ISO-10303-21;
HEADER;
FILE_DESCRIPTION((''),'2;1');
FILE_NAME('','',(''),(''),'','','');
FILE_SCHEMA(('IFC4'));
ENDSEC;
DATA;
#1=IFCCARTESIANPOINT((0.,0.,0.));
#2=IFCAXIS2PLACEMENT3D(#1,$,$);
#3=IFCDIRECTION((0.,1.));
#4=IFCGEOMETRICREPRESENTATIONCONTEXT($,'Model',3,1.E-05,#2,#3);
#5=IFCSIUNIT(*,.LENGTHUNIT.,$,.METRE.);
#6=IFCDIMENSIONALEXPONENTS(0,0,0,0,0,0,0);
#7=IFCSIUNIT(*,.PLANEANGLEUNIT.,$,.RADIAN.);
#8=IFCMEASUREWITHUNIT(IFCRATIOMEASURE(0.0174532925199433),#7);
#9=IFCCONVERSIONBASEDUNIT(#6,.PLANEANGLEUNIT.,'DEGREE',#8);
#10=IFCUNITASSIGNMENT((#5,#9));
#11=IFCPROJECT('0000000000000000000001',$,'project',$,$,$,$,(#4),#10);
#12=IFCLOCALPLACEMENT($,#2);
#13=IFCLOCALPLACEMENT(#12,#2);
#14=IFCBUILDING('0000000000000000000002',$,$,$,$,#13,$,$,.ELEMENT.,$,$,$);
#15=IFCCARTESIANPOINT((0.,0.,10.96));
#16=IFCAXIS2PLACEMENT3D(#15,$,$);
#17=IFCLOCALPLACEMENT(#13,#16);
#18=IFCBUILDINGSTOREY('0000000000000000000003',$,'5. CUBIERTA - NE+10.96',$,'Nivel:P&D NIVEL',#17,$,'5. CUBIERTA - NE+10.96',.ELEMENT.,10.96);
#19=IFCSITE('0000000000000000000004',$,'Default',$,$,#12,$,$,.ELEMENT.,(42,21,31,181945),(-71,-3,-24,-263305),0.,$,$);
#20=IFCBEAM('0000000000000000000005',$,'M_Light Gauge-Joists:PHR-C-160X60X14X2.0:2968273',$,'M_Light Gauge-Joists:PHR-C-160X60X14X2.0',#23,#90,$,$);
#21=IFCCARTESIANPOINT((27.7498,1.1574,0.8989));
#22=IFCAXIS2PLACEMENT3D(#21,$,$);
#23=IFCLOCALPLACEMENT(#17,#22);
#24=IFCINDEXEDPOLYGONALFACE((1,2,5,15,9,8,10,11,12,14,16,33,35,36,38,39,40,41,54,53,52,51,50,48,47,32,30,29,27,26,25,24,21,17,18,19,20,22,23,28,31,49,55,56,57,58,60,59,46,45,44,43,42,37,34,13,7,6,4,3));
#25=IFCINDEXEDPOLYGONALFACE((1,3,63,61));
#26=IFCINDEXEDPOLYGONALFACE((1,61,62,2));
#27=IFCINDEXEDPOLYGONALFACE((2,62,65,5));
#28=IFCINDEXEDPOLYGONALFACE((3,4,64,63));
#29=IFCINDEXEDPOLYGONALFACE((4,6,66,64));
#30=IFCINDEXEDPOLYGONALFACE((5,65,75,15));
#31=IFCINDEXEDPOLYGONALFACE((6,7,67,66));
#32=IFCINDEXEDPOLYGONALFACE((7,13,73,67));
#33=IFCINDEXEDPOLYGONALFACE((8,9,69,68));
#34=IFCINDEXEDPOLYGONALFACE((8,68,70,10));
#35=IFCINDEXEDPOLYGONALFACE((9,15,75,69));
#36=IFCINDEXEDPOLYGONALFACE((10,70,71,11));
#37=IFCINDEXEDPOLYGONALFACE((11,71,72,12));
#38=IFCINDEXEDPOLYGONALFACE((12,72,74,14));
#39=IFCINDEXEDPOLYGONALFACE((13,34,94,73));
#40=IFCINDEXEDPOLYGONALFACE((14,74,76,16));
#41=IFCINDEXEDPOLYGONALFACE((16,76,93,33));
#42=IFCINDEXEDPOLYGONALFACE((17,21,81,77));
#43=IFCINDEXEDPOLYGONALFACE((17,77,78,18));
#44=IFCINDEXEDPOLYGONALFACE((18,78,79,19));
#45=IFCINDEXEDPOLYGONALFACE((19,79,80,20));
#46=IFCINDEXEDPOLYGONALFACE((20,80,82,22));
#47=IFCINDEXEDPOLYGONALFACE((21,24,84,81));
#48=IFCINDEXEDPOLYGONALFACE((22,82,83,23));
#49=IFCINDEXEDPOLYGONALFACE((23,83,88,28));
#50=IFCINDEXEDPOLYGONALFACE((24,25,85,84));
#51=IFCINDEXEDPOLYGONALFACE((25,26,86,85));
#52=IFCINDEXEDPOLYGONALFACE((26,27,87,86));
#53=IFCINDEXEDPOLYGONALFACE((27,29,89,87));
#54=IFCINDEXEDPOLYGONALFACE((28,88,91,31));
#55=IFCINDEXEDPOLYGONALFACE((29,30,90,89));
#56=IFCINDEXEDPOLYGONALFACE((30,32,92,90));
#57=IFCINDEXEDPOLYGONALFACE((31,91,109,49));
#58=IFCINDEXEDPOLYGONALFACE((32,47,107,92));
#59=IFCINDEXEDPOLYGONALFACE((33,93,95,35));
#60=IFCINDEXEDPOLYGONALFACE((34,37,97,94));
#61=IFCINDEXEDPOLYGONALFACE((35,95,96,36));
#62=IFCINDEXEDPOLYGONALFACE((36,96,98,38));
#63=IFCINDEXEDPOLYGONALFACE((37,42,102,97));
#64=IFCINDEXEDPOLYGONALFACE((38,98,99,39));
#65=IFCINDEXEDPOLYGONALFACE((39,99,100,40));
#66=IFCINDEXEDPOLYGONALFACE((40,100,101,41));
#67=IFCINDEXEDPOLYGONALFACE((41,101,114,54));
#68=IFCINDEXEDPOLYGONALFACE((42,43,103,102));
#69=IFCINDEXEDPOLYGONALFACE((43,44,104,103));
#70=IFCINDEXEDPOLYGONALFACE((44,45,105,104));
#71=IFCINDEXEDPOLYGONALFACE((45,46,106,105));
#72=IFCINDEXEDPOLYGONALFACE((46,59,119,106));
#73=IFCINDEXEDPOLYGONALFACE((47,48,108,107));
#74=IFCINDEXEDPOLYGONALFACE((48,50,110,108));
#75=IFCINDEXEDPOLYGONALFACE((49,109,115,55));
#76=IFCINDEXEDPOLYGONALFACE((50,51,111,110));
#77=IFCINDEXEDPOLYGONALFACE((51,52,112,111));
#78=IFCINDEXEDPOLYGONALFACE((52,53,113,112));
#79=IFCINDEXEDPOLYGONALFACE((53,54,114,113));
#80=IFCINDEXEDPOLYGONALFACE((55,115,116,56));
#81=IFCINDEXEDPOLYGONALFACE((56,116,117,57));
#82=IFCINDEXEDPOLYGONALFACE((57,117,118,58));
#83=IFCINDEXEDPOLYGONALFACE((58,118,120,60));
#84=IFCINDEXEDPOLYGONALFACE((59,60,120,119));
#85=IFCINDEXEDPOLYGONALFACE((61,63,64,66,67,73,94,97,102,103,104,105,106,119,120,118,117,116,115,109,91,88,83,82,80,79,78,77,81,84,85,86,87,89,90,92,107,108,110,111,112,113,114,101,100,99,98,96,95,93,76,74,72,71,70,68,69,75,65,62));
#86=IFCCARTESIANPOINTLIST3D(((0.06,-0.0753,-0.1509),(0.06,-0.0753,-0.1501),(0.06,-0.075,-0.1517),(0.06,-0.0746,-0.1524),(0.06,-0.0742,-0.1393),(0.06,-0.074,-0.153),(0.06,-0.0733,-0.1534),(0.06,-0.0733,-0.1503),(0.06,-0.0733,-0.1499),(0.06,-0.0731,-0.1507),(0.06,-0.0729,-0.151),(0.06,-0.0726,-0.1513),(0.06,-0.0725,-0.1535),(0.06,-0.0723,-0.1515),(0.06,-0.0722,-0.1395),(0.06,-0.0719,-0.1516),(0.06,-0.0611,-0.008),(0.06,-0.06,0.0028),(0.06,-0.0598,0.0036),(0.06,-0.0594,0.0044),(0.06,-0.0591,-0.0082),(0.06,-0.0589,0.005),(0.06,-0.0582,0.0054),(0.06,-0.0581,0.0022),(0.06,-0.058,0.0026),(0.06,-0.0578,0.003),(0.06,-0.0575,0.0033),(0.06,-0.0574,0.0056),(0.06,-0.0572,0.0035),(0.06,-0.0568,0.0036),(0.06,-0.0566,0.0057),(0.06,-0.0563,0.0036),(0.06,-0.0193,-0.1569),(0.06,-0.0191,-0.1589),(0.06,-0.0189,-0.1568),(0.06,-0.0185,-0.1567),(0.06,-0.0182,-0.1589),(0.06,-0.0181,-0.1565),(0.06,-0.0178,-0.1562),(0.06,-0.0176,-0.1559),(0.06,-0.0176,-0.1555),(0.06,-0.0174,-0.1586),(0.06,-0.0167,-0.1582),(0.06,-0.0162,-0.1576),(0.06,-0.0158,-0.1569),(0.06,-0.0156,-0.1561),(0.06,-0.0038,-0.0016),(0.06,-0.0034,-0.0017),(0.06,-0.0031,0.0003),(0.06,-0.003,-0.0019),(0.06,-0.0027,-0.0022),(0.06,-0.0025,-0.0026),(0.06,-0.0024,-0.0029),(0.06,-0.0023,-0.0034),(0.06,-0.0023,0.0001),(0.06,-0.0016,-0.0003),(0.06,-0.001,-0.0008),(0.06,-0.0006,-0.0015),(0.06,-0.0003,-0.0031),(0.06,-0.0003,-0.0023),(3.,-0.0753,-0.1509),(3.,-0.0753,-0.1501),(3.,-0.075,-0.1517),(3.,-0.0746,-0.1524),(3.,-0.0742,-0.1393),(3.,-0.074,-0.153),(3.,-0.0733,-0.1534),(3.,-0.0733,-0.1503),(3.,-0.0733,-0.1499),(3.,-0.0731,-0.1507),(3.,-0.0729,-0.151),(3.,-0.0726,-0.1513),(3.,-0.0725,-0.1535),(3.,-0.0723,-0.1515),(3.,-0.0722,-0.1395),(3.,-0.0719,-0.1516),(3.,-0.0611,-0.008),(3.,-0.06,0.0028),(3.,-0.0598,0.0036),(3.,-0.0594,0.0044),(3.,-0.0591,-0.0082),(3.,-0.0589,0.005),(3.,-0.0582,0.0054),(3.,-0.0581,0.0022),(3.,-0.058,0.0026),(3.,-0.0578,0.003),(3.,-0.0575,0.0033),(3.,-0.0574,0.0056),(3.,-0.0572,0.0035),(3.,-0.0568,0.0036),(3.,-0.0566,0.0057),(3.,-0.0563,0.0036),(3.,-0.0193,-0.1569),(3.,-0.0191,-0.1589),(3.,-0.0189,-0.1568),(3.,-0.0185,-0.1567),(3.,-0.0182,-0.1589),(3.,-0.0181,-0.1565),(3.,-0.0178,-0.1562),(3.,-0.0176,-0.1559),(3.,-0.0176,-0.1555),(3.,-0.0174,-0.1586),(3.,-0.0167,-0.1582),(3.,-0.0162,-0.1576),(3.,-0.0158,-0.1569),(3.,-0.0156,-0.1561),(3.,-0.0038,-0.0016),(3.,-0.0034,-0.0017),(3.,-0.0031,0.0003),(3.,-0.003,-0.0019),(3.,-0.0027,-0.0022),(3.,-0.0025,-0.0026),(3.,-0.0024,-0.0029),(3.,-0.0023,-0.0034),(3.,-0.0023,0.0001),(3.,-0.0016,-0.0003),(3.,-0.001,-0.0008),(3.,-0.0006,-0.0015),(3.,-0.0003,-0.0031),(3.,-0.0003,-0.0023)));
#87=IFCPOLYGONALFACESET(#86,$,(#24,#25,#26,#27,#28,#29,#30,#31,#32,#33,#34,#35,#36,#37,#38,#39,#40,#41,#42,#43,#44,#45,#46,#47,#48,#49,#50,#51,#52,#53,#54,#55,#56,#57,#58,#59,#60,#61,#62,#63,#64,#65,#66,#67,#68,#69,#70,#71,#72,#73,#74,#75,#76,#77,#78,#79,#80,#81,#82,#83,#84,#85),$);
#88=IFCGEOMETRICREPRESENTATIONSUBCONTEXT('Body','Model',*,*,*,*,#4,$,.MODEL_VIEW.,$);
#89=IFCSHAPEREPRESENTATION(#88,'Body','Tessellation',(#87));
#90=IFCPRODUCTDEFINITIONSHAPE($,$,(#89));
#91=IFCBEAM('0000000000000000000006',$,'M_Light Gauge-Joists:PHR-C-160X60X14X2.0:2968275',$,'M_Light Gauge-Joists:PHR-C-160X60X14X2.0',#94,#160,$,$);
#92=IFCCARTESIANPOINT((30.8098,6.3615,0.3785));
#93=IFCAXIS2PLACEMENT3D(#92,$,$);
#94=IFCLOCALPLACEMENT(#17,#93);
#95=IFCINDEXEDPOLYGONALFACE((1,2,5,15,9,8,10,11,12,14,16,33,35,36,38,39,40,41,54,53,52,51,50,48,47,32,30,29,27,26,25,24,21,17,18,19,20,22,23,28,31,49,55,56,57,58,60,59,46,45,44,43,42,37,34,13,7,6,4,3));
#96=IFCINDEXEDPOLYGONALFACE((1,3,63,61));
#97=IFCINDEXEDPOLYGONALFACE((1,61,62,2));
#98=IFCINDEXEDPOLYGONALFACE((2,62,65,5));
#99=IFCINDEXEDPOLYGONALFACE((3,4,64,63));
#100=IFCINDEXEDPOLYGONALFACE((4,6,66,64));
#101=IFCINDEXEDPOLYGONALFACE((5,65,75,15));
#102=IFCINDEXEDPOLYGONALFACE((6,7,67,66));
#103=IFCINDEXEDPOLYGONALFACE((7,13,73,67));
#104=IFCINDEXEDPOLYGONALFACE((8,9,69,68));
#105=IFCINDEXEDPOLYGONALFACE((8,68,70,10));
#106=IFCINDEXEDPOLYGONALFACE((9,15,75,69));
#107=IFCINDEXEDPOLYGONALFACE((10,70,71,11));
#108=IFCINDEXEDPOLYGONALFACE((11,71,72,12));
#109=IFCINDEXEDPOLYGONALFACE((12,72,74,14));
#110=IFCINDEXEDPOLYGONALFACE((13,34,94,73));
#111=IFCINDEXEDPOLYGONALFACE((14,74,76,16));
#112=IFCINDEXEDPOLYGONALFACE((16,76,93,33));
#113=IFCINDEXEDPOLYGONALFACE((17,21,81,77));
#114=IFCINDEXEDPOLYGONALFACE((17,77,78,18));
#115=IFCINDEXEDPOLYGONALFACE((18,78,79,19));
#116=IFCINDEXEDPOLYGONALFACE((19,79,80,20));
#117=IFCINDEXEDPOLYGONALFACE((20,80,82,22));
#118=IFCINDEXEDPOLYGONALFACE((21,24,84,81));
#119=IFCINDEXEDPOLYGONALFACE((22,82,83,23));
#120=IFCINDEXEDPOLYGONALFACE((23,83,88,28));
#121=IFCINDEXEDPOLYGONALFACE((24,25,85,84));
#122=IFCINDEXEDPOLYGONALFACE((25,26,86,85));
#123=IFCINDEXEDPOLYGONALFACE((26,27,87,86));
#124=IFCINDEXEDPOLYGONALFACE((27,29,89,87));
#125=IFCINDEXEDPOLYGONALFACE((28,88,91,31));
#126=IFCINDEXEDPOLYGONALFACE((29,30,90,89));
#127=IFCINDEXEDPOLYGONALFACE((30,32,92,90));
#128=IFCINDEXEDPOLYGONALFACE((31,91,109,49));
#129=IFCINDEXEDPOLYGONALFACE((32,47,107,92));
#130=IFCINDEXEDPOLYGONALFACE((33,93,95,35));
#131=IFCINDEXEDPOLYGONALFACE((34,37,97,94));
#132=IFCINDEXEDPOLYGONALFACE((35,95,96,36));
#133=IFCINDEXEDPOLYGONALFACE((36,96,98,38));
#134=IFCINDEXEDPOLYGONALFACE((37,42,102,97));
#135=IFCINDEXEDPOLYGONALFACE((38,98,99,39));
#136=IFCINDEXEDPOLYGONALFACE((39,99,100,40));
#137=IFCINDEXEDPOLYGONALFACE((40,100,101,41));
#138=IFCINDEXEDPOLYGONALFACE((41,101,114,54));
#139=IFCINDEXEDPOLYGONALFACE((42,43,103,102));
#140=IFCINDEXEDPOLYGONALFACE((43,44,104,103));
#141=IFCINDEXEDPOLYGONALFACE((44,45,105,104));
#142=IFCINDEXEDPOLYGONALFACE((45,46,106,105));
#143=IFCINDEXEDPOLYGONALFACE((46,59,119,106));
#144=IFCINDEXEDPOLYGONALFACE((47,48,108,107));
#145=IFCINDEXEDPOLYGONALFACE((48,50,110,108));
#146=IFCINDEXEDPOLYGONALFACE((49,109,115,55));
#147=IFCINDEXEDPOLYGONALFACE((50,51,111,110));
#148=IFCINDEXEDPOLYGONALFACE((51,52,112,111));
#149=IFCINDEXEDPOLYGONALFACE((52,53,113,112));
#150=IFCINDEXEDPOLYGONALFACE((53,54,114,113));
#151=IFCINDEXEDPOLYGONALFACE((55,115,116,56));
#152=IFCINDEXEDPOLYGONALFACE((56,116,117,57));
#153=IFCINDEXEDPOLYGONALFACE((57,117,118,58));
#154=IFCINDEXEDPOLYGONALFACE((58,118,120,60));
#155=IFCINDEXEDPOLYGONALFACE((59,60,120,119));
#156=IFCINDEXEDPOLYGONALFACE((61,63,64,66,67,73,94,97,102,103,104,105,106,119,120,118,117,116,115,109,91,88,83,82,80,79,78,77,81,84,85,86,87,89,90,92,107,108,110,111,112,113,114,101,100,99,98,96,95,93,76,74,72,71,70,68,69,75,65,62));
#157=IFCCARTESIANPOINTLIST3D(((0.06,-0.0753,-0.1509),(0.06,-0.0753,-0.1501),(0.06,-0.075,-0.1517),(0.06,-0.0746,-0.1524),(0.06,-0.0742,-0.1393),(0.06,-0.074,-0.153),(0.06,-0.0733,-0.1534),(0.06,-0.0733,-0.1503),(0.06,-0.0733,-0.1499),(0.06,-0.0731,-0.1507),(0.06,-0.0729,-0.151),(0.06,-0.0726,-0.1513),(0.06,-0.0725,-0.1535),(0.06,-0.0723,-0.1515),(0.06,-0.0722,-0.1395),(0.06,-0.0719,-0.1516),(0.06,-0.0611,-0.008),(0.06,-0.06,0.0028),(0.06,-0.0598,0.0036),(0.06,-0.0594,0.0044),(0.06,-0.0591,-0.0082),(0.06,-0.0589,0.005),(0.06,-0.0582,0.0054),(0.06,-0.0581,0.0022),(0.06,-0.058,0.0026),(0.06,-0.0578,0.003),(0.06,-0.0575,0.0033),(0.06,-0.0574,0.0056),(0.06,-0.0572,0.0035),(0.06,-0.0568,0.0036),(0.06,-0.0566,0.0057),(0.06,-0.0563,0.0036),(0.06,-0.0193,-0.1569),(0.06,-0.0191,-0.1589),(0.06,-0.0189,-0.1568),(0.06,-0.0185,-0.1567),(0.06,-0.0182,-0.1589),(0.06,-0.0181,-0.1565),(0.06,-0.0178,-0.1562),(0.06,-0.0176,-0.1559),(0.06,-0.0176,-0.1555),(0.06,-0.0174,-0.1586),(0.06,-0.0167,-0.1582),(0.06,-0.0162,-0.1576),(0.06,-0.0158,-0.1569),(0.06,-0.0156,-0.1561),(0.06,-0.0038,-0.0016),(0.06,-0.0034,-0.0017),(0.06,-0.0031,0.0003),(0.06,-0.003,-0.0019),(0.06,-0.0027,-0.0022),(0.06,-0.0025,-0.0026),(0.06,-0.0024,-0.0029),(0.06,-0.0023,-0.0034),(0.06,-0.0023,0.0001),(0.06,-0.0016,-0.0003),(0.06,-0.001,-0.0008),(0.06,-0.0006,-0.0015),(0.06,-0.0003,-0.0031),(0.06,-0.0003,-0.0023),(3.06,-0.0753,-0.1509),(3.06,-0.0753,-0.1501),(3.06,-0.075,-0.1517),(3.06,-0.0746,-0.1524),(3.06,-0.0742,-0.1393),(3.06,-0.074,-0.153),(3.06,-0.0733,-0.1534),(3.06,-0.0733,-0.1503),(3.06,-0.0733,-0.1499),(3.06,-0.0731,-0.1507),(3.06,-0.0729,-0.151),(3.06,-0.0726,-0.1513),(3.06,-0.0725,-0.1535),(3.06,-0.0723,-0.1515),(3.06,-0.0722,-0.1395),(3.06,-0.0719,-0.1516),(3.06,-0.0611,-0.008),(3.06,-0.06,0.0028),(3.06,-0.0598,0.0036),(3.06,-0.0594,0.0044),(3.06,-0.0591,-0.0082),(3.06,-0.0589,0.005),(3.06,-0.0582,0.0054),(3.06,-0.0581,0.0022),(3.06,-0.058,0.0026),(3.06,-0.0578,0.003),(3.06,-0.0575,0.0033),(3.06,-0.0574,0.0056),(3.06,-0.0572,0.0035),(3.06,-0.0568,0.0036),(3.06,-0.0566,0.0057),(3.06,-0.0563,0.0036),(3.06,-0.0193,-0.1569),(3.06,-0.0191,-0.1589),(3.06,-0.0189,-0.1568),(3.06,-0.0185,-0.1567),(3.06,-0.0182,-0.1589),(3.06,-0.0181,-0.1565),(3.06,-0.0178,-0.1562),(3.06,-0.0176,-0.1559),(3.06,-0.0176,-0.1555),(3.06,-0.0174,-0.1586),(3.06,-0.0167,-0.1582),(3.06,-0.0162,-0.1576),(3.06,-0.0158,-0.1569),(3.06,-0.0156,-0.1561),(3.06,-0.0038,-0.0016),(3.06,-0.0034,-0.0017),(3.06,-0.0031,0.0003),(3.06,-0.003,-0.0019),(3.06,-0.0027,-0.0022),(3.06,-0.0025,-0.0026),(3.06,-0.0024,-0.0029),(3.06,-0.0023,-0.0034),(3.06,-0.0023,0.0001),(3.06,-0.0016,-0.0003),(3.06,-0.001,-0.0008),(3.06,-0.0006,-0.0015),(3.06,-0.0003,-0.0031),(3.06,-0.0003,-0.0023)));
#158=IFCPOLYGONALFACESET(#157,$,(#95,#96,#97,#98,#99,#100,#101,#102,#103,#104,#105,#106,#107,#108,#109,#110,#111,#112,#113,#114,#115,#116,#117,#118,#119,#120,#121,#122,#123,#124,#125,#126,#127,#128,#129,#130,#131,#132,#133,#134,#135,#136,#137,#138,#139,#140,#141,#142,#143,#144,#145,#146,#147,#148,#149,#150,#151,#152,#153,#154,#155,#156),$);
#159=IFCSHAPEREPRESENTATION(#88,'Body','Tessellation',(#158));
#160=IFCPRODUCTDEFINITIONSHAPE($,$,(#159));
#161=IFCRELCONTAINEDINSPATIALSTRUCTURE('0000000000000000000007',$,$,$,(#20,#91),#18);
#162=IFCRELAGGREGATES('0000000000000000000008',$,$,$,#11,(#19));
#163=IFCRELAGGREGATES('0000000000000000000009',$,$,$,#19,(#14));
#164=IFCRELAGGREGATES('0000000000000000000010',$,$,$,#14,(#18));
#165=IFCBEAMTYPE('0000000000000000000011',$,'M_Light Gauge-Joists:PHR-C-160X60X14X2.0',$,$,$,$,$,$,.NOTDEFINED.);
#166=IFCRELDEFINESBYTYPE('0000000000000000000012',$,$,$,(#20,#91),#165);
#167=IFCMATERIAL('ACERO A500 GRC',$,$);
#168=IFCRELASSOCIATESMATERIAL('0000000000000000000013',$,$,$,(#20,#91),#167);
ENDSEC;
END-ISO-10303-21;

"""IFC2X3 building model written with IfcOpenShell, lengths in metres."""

from ifc_helpers import new_model, entity, si_unit, converted_unit, direction, frame, frame_2d, origin, place, context, subcontext, project, spatial, polyline, circle_curve, parameter, trimmed, segment, composite_curve, outline, extrude, material, type_object, element, save


model = new_model("IFC2X3")

# Units and contexts
model_context = context("Model", 3, precision=1e-05, world=origin(), true_north=direction((0.0, 1.0)))
body_context = subcontext(model_context, "Body", "Model", "MODEL_VIEW")
ifc_project = project(units=[si_unit("LENGTHUNIT", "METRE"), converted_unit("PLANEANGLEUNIT", "DEGREE", entity("IfcRatioMeasure", 0.0174532925199433), si_unit("PLANEANGLEUNIT", "RADIAN"), dimensions=[0, 0, 0, 0, 0, 0, 0])], contexts=[model_context])

# Site, building, storey
site_placement = place(None, origin())
site = spatial("IfcSite", under=ifc_project, at=site_placement, Name="Default", CompositionType="ELEMENT", RefLatitude=(42, 21, 31, 181945), RefLongitude=(-71, -3, -24, -263305), RefElevation=0.0)
building_placement = place(site_placement, origin())
building = spatial("IfcBuilding", under=site, at=building_placement, CompositionType="ELEMENT")
storey_placement = place(building_placement, frame((0.0, 0.0, 10.96)))
storey = spatial("IfcBuildingStorey", under=building, at=storey_placement, Name="5. CUBIERTA - NE+10.96", ObjectType="Nivel:P&D NIVEL", LongName="5. CUBIERTA - NE+10.96", CompositionType="ELEMENT", Elevation=10.96)

# Beams
ifc_material_1 = material(Name="ACERO A500 GRC")
beam_type_1 = type_object("IfcBeamType", Name="M_Light Gauge-Joists:PHR-C-160X60X14X2.0", PredefinedType="NOTDEFINED")
beam_1_placement = place(storey_placement, frame((27.7498, 1.1574, 0.8989)))
element("IfcBeam", 1, at=beam_1_placement, inside=storey, type_object=beam_type_1, material=ifc_material_1, Name="M_Light Gauge-Joists:PHR-C-160X60X14X2.0:2968273", ObjectType="M_Light Gauge-Joists:PHR-C-160X60X14X2.0", context=body_context, shape_type="SweptSolid", body=[
    extrude(outline(composite_curve([segment(polyline([(-0.0768, -0.0358), (0.0768, -0.0358)]), True, "CONTINUOUS"), segment(trimmed(circle_curve(frame_2d((0.0768, -0.0326), x_axis=(0.0, -1.0)), 0.0032), [parameter(0.0)], [parameter(90.0)], True, "PARAMETER"), True, "CONTINUOUS"), segment(polyline([(0.08, -0.0326), (0.08, 0.021)]), True, "CONTINUOUS"), segment(trimmed(circle_curve(frame_2d((0.0768, 0.021), x_axis=(1.0, 0.0)), 0.0032), [parameter(0.0)], [parameter(90.0)], True, "PARAMETER"), True, "CONTINUOUS"), segment(polyline([(0.0768, 0.0242), (0.066, 0.0242)]), True, "CONTINUOUS"), segment(polyline([(0.066, 0.0242), (0.066, 0.0222)]), True, "CONTINUOUS"), segment(polyline([(0.066, 0.0222), (0.0764, 0.0222)]), True, "CONTINUOUS"), segment(trimmed(circle_curve(frame_2d((0.0764, 0.0206), x_axis=(0.0, 1.0)), 0.0016), [parameter(270.0)], [parameter(0.0)], True, "PARAMETER"), False, "CONTINUOUS"), segment(polyline([(0.078, 0.0206), (0.078, -0.0322)]), True, "CONTINUOUS"), segment(trimmed(circle_curve(frame_2d((0.0764, -0.0322), x_axis=(1.0, 0.0)), 0.0016), [parameter(270.0)], [parameter(0.0)], True, "PARAMETER"), False, "CONTINUOUS"), segment(polyline([(0.0764, -0.0338), (-0.0764, -0.0338)]), True, "CONTINUOUS"), segment(trimmed(circle_curve(frame_2d((-0.0764, -0.0322), x_axis=(0.0, -1.0)), 0.0016), [parameter(270.0)], [parameter(0.0)], True, "PARAMETER"), False, "CONTINUOUS"), segment(polyline([(-0.078, -0.0322), (-0.078, 0.0206)]), True, "CONTINUOUS"), segment(trimmed(circle_curve(frame_2d((-0.0764, 0.0206), x_axis=(-1.0, 0.0)), 0.0016), [parameter(270.0)], [parameter(0.0)], True, "PARAMETER"), False, "CONTINUOUS"), segment(polyline([(-0.0764, 0.0222), (-0.066, 0.0222)]), True, "CONTINUOUS"), segment(polyline([(-0.066, 0.0222), (-0.066, 0.0242)]), True, "CONTINUOUS"), segment(polyline([(-0.066, 0.0242), (-0.0768, 0.0242)]), True, "CONTINUOUS"), segment(trimmed(circle_curve(frame_2d((-0.0768, 0.021), x_axis=(0.0, 1.0)), 0.0032), [parameter(0.0)], [parameter(90.0)], True, "PARAMETER"), True, "CONTINUOUS"), segment(polyline([(-0.08, 0.021), (-0.08, -0.0326)]), True, "CONTINUOUS"), segment(trimmed(circle_curve(frame_2d((-0.0768, -0.0326), x_axis=(-1.0, 0.0)), 0.0032), [parameter(0.0)], [parameter(90.0)], True, "PARAMETER"), True, "CONTINUOUS")], self_intersect=False)), frame((0.06, -0.0436, -0.076), z_axis=(1.0, 0.0, 0.0), x_axis=(0.0, 0.099504, 0.995037)), (0.0, 0.0, 1.0), 2.94),
])
beam_2_placement = place(storey_placement, frame((30.8098, 6.3615, 0.3785)))
element("IfcBeam", 2, at=beam_2_placement, inside=storey, type_object=beam_type_1, material=ifc_material_1, Name="M_Light Gauge-Joists:PHR-C-160X60X14X2.0:2968275", ObjectType="M_Light Gauge-Joists:PHR-C-160X60X14X2.0", context=body_context, shape_type="SweptSolid", body=[
    extrude(outline(composite_curve([segment(polyline([(-0.0768, -0.0358), (0.0768, -0.0358)]), True, "CONTINUOUS"), segment(trimmed(circle_curve(frame_2d((0.0768, -0.0326), x_axis=(0.0, -1.0)), 0.0032), [parameter(0.0)], [parameter(90.0)], True, "PARAMETER"), True, "CONTINUOUS"), segment(polyline([(0.08, -0.0326), (0.08, 0.021)]), True, "CONTINUOUS"), segment(trimmed(circle_curve(frame_2d((0.0768, 0.021), x_axis=(1.0, 0.0)), 0.0032), [parameter(0.0)], [parameter(90.0)], True, "PARAMETER"), True, "CONTINUOUS"), segment(polyline([(0.0768, 0.0242), (0.066, 0.0242)]), True, "CONTINUOUS"), segment(polyline([(0.066, 0.0242), (0.066, 0.0222)]), True, "CONTINUOUS"), segment(polyline([(0.066, 0.0222), (0.0764, 0.0222)]), True, "CONTINUOUS"), segment(trimmed(circle_curve(frame_2d((0.0764, 0.0206), x_axis=(0.0, 1.0)), 0.0016), [parameter(270.0)], [parameter(0.0)], True, "PARAMETER"), False, "CONTINUOUS"), segment(polyline([(0.078, 0.0206), (0.078, -0.0322)]), True, "CONTINUOUS"), segment(trimmed(circle_curve(frame_2d((0.0764, -0.0322), x_axis=(1.0, 0.0)), 0.0016), [parameter(270.0)], [parameter(0.0)], True, "PARAMETER"), False, "CONTINUOUS"), segment(polyline([(0.0764, -0.0338), (-0.0764, -0.0338)]), True, "CONTINUOUS"), segment(trimmed(circle_curve(frame_2d((-0.0764, -0.0322), x_axis=(0.0, -1.0)), 0.0016), [parameter(270.0)], [parameter(0.0)], True, "PARAMETER"), False, "CONTINUOUS"), segment(polyline([(-0.078, -0.0322), (-0.078, 0.0206)]), True, "CONTINUOUS"), segment(trimmed(circle_curve(frame_2d((-0.0764, 0.0206), x_axis=(-1.0, 0.0)), 0.0016), [parameter(270.0)], [parameter(0.0)], True, "PARAMETER"), False, "CONTINUOUS"), segment(polyline([(-0.0764, 0.0222), (-0.066, 0.0222)]), True, "CONTINUOUS"), segment(polyline([(-0.066, 0.0222), (-0.066, 0.0242)]), True, "CONTINUOUS"), segment(polyline([(-0.066, 0.0242), (-0.0768, 0.0242)]), True, "CONTINUOUS"), segment(trimmed(circle_curve(frame_2d((-0.0768, 0.021), x_axis=(0.0, 1.0)), 0.0032), [parameter(0.0)], [parameter(90.0)], True, "PARAMETER"), True, "CONTINUOUS"), segment(polyline([(-0.08, 0.021), (-0.08, -0.0326)]), True, "CONTINUOUS"), segment(trimmed(circle_curve(frame_2d((-0.0768, -0.0326), x_axis=(-1.0, 0.0)), 0.0032), [parameter(0.0)], [parameter(90.0)], True, "PARAMETER"), True, "CONTINUOUS")], self_intersect=False)), frame((0.06, -0.0436, -0.076), z_axis=(1.0, 0.0, 0.0), x_axis=(0.0, 0.099504, 0.995037)), (0.0, 0.0, 1.0), 3.0),
])

save(model, "model.ifc")
